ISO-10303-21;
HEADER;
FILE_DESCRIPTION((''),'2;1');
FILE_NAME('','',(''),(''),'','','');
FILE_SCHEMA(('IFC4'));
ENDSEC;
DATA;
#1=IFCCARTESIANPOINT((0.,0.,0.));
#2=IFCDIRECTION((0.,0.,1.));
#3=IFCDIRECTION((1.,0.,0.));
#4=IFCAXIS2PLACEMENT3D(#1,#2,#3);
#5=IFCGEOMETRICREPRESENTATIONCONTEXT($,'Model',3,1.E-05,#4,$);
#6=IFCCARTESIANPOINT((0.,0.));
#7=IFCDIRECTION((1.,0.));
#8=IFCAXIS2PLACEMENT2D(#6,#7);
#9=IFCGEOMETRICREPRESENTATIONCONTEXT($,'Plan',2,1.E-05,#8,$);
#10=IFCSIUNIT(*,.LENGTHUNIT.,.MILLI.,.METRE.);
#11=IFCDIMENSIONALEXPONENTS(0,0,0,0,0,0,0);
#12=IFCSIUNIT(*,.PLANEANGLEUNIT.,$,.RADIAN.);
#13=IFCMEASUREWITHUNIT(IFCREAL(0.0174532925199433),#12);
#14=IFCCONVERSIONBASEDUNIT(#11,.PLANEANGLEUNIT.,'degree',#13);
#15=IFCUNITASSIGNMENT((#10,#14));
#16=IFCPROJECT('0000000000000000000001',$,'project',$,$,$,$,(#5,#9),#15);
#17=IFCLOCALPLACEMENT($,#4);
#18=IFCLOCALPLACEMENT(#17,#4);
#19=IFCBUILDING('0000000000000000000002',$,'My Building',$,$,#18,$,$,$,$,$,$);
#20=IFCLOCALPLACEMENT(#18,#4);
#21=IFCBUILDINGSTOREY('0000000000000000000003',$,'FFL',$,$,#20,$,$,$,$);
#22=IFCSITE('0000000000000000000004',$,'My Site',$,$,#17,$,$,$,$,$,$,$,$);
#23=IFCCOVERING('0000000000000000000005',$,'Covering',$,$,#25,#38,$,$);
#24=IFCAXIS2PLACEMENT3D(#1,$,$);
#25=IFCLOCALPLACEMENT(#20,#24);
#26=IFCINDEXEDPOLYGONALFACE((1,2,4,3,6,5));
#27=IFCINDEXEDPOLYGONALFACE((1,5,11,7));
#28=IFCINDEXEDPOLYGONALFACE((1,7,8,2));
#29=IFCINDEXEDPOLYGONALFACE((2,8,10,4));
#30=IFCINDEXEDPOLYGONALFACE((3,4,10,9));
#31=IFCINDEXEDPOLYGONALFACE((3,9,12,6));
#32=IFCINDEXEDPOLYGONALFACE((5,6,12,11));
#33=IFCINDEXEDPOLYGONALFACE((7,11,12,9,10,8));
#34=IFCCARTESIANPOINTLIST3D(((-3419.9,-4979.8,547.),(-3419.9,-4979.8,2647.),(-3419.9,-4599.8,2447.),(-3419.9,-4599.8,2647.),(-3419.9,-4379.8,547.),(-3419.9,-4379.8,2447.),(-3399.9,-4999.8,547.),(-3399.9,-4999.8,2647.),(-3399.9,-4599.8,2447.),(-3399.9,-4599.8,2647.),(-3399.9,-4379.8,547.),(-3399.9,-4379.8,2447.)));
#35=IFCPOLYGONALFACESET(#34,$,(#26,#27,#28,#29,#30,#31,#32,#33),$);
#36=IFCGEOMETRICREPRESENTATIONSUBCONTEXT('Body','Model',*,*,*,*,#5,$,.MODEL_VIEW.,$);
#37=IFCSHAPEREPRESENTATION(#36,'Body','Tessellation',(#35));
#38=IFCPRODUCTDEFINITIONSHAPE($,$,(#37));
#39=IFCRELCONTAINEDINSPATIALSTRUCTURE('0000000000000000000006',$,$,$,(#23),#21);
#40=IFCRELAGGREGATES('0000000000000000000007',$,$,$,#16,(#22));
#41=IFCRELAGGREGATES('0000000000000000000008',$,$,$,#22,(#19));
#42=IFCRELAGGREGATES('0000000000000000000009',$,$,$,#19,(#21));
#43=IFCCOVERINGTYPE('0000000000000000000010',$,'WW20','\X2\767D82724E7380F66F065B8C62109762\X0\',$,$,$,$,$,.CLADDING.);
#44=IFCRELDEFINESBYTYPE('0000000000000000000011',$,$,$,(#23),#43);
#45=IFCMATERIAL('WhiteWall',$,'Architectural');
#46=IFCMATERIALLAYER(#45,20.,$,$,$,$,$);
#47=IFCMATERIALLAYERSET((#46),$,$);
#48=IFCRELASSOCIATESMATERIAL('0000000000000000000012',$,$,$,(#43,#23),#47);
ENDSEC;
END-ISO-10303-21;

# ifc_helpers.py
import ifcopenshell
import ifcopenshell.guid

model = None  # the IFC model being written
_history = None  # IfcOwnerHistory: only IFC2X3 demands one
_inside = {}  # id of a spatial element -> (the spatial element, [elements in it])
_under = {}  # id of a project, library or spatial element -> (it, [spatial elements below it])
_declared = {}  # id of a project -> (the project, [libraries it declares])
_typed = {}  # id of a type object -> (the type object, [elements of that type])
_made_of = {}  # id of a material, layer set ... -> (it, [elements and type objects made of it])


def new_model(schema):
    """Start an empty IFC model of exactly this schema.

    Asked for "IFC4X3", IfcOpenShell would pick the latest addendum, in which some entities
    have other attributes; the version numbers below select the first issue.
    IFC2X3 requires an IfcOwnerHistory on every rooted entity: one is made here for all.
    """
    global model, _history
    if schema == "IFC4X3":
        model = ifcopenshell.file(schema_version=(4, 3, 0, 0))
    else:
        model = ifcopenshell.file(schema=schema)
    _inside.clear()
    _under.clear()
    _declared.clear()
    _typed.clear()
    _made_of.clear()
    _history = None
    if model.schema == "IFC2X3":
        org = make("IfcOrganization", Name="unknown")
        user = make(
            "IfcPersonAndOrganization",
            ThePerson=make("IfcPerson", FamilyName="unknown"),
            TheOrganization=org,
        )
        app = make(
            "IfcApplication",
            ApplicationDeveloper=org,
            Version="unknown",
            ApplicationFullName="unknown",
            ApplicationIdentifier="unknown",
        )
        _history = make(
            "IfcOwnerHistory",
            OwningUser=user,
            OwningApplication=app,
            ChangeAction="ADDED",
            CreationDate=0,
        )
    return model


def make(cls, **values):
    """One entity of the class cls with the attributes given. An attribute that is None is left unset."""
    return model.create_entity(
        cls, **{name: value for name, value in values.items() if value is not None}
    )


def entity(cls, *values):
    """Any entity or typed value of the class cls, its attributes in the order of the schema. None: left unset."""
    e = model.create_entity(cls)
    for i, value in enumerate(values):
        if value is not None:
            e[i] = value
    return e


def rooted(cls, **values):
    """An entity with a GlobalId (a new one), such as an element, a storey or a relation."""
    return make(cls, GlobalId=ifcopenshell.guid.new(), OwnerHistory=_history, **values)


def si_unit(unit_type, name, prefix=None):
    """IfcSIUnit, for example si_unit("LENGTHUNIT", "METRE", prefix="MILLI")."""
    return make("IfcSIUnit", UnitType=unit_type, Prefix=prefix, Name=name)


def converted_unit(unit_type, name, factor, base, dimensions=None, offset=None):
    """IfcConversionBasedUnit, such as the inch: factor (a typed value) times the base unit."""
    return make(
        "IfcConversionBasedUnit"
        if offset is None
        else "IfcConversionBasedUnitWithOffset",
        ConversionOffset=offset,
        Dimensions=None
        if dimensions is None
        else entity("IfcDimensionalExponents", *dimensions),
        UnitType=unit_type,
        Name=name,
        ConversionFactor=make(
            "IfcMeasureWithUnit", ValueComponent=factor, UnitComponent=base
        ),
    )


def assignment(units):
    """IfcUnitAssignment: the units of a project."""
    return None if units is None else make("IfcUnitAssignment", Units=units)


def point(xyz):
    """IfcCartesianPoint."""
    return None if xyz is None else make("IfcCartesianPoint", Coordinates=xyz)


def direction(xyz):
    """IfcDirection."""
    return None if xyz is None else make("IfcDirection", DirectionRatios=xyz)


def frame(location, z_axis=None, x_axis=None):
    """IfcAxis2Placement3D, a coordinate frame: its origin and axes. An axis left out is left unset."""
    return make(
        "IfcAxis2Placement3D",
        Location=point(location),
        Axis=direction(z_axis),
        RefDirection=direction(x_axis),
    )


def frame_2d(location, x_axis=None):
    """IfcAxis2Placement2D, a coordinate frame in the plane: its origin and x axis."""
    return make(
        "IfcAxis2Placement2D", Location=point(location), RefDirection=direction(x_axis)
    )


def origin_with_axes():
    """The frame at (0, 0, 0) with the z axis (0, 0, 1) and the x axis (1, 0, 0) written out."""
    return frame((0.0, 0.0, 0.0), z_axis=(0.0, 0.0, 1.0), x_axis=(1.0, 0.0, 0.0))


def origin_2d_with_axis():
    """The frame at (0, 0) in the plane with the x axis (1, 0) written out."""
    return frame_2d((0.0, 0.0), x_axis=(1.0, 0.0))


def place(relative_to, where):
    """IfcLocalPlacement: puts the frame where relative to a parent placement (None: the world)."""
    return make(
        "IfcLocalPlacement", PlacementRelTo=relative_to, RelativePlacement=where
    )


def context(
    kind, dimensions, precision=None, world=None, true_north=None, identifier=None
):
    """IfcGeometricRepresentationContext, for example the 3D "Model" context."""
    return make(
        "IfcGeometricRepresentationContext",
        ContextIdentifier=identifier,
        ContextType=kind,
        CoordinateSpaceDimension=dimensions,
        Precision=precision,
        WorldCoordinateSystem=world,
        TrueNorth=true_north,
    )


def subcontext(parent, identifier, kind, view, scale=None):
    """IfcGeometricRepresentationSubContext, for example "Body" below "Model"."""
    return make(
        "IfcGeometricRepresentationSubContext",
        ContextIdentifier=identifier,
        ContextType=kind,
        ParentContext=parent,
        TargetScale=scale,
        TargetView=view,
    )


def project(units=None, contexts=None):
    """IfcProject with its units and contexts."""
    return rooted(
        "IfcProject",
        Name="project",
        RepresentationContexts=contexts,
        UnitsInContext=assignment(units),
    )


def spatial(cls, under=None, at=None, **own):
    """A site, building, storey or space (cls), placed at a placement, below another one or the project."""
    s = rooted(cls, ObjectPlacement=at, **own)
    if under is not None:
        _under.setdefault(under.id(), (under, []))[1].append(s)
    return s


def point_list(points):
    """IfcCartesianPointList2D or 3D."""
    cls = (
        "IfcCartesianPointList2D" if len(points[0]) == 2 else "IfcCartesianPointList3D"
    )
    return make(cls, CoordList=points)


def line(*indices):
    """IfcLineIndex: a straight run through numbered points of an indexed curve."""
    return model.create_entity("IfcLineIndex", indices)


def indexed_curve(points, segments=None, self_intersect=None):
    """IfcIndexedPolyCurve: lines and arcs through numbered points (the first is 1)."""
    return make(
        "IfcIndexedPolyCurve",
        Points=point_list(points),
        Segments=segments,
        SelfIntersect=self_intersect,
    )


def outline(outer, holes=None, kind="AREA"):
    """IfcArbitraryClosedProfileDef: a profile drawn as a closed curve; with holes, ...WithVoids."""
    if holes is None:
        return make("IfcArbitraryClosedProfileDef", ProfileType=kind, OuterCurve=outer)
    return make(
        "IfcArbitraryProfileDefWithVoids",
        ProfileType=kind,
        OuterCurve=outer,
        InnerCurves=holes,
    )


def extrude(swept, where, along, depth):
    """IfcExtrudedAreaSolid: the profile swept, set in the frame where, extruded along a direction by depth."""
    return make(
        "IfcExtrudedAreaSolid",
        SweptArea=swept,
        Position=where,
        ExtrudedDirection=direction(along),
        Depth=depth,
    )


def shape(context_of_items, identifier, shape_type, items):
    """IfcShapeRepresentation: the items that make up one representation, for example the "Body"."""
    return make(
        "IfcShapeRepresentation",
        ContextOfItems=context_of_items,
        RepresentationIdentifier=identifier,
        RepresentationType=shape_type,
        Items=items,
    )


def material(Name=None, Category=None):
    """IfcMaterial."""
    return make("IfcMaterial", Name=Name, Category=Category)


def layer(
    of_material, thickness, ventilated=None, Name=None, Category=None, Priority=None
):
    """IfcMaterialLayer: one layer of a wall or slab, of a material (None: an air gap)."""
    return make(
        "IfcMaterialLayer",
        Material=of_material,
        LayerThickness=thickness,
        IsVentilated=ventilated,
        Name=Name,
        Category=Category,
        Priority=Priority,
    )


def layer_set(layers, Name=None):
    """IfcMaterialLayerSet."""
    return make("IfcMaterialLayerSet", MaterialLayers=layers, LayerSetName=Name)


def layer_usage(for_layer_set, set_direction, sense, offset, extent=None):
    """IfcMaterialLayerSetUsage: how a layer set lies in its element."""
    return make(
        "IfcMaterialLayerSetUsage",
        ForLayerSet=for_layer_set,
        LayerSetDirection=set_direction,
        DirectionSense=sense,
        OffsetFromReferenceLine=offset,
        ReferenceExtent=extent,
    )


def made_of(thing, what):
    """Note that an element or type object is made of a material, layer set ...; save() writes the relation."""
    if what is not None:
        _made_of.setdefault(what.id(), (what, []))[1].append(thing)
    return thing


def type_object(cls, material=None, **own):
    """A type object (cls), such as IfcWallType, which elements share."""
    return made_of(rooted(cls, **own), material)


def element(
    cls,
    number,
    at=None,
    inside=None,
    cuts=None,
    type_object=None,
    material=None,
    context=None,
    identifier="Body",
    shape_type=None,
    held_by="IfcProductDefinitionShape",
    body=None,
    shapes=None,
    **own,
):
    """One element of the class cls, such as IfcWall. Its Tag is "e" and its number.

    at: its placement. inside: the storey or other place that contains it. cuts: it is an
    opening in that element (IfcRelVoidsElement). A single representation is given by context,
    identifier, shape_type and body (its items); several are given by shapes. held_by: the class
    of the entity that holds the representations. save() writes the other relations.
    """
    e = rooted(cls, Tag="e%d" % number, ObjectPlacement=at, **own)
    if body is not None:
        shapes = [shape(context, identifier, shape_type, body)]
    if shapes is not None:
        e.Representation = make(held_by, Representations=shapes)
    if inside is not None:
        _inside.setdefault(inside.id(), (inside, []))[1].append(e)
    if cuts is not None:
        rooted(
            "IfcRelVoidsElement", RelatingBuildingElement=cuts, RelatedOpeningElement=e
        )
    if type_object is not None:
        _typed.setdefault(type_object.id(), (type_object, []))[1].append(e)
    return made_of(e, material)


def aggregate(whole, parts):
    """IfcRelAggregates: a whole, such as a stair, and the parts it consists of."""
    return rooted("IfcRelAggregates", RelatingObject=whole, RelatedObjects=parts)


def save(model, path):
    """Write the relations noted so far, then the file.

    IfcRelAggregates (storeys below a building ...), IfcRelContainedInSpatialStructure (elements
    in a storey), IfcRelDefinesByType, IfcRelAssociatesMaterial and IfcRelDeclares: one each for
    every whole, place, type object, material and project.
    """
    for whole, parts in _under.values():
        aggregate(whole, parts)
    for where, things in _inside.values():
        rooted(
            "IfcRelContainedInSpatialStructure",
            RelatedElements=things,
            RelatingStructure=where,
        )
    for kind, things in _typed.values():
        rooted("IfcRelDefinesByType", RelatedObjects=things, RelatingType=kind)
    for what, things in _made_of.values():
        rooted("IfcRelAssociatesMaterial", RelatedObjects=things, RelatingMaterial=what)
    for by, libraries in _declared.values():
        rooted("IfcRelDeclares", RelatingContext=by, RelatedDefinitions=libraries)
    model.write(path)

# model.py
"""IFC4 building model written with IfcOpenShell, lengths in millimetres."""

from ifc_helpers import new_model, entity, si_unit, converted_unit, frame, origin_with_axes, origin_2d_with_axis, place, context, subcontext, project, spatial, line, indexed_curve, outline, extrude, material, layer, layer_set, layer_usage, type_object, element, save


model = new_model("IFC4")

# Units and contexts
model_context = context("Model", 3, precision=1e-05, world=origin_with_axes())
plan_context = context("Plan", 2, precision=1e-05, world=origin_2d_with_axis())
body_context_1 = subcontext(model_context, "Body", "Model", "MODEL_VIEW")
ifc_project = project(units=[si_unit("LENGTHUNIT", "METRE", prefix="MILLI"), converted_unit("PLANEANGLEUNIT", "degree", entity("IfcReal", 0.0174532925199433), si_unit("PLANEANGLEUNIT", "RADIAN"), dimensions=[0, 0, 0, 0, 0, 0, 0])], contexts=[model_context, plan_context])

# Site, building, storey
site_placement = place(None, origin_with_axes())
site = spatial("IfcSite", under=ifc_project, at=site_placement, Name="My Site")
building_placement = place(site_placement, origin_with_axes())
building = spatial("IfcBuilding", under=site, at=building_placement, Name="My Building")
storey_placement = place(building_placement, origin_with_axes())
storey = spatial("IfcBuildingStorey", under=building, at=storey_placement, Name="FFL")

# Shared definitions
ifc_material_1 = material(Name="WhiteWall", Category="Architectural")
ifc_layer_1 = layer(ifc_material_1, 20.0)
ifc_layer_set_1 = layer_set([ifc_layer_1])
covering_type = type_object("IfcCoveringType", Name="WW20", Description="白色乳胶漆完成面", PredefinedType="CLADDING", material=ifc_layer_set_1)

# Covering, opening
ifc_layer_usage_1 = layer_usage(ifc_layer_set_1, "AXIS2", "POSITIVE", 0.0)
covering_1_placement = place(storey_placement, frame((-3399.9, -4999.8, 547.0), z_axis=(0.0, 0.0, 1.0), x_axis=(0.000002, 1.0, 0.0)))
covering_1 = element("IfcCovering", 1, at=covering_1_placement, inside=storey, type_object=covering_type, material=ifc_layer_usage_1, Name="Covering", context=body_context_1, shape_type="SweptSolid", body=[
    extrude(outline(indexed_curve([(0.0, 0.0), (20.0, 20.0), (620.0, 20.0), (620.0, 0.0)], segments=[line(1, 2, 3, 4, 1)])), origin_with_axes(), (0.0, 0.0, 1.0), 2100.0),
])
opening_1_placement = place(covering_1_placement, frame((620.0, 120.0, 1900.0), z_axis=(0.000001, -1.0, 0.0), x_axis=(0.0, 0.0, 1.0)))
element("IfcOpeningElement", 2, at=opening_1_placement, cuts=covering_1, PredefinedType="OPENING", context=body_context_1, shape_type="SweptSolid", body=[
    extrude(outline(indexed_curve([(0.0, 220.0), (500.0, 220.0), (500.0, -100.0), (0.0, -100.0), (0.0, 220.0)])), origin_with_axes(), (0.0, 0.0, 1.0), 500.0),
])

save(model, "model.ifc")
